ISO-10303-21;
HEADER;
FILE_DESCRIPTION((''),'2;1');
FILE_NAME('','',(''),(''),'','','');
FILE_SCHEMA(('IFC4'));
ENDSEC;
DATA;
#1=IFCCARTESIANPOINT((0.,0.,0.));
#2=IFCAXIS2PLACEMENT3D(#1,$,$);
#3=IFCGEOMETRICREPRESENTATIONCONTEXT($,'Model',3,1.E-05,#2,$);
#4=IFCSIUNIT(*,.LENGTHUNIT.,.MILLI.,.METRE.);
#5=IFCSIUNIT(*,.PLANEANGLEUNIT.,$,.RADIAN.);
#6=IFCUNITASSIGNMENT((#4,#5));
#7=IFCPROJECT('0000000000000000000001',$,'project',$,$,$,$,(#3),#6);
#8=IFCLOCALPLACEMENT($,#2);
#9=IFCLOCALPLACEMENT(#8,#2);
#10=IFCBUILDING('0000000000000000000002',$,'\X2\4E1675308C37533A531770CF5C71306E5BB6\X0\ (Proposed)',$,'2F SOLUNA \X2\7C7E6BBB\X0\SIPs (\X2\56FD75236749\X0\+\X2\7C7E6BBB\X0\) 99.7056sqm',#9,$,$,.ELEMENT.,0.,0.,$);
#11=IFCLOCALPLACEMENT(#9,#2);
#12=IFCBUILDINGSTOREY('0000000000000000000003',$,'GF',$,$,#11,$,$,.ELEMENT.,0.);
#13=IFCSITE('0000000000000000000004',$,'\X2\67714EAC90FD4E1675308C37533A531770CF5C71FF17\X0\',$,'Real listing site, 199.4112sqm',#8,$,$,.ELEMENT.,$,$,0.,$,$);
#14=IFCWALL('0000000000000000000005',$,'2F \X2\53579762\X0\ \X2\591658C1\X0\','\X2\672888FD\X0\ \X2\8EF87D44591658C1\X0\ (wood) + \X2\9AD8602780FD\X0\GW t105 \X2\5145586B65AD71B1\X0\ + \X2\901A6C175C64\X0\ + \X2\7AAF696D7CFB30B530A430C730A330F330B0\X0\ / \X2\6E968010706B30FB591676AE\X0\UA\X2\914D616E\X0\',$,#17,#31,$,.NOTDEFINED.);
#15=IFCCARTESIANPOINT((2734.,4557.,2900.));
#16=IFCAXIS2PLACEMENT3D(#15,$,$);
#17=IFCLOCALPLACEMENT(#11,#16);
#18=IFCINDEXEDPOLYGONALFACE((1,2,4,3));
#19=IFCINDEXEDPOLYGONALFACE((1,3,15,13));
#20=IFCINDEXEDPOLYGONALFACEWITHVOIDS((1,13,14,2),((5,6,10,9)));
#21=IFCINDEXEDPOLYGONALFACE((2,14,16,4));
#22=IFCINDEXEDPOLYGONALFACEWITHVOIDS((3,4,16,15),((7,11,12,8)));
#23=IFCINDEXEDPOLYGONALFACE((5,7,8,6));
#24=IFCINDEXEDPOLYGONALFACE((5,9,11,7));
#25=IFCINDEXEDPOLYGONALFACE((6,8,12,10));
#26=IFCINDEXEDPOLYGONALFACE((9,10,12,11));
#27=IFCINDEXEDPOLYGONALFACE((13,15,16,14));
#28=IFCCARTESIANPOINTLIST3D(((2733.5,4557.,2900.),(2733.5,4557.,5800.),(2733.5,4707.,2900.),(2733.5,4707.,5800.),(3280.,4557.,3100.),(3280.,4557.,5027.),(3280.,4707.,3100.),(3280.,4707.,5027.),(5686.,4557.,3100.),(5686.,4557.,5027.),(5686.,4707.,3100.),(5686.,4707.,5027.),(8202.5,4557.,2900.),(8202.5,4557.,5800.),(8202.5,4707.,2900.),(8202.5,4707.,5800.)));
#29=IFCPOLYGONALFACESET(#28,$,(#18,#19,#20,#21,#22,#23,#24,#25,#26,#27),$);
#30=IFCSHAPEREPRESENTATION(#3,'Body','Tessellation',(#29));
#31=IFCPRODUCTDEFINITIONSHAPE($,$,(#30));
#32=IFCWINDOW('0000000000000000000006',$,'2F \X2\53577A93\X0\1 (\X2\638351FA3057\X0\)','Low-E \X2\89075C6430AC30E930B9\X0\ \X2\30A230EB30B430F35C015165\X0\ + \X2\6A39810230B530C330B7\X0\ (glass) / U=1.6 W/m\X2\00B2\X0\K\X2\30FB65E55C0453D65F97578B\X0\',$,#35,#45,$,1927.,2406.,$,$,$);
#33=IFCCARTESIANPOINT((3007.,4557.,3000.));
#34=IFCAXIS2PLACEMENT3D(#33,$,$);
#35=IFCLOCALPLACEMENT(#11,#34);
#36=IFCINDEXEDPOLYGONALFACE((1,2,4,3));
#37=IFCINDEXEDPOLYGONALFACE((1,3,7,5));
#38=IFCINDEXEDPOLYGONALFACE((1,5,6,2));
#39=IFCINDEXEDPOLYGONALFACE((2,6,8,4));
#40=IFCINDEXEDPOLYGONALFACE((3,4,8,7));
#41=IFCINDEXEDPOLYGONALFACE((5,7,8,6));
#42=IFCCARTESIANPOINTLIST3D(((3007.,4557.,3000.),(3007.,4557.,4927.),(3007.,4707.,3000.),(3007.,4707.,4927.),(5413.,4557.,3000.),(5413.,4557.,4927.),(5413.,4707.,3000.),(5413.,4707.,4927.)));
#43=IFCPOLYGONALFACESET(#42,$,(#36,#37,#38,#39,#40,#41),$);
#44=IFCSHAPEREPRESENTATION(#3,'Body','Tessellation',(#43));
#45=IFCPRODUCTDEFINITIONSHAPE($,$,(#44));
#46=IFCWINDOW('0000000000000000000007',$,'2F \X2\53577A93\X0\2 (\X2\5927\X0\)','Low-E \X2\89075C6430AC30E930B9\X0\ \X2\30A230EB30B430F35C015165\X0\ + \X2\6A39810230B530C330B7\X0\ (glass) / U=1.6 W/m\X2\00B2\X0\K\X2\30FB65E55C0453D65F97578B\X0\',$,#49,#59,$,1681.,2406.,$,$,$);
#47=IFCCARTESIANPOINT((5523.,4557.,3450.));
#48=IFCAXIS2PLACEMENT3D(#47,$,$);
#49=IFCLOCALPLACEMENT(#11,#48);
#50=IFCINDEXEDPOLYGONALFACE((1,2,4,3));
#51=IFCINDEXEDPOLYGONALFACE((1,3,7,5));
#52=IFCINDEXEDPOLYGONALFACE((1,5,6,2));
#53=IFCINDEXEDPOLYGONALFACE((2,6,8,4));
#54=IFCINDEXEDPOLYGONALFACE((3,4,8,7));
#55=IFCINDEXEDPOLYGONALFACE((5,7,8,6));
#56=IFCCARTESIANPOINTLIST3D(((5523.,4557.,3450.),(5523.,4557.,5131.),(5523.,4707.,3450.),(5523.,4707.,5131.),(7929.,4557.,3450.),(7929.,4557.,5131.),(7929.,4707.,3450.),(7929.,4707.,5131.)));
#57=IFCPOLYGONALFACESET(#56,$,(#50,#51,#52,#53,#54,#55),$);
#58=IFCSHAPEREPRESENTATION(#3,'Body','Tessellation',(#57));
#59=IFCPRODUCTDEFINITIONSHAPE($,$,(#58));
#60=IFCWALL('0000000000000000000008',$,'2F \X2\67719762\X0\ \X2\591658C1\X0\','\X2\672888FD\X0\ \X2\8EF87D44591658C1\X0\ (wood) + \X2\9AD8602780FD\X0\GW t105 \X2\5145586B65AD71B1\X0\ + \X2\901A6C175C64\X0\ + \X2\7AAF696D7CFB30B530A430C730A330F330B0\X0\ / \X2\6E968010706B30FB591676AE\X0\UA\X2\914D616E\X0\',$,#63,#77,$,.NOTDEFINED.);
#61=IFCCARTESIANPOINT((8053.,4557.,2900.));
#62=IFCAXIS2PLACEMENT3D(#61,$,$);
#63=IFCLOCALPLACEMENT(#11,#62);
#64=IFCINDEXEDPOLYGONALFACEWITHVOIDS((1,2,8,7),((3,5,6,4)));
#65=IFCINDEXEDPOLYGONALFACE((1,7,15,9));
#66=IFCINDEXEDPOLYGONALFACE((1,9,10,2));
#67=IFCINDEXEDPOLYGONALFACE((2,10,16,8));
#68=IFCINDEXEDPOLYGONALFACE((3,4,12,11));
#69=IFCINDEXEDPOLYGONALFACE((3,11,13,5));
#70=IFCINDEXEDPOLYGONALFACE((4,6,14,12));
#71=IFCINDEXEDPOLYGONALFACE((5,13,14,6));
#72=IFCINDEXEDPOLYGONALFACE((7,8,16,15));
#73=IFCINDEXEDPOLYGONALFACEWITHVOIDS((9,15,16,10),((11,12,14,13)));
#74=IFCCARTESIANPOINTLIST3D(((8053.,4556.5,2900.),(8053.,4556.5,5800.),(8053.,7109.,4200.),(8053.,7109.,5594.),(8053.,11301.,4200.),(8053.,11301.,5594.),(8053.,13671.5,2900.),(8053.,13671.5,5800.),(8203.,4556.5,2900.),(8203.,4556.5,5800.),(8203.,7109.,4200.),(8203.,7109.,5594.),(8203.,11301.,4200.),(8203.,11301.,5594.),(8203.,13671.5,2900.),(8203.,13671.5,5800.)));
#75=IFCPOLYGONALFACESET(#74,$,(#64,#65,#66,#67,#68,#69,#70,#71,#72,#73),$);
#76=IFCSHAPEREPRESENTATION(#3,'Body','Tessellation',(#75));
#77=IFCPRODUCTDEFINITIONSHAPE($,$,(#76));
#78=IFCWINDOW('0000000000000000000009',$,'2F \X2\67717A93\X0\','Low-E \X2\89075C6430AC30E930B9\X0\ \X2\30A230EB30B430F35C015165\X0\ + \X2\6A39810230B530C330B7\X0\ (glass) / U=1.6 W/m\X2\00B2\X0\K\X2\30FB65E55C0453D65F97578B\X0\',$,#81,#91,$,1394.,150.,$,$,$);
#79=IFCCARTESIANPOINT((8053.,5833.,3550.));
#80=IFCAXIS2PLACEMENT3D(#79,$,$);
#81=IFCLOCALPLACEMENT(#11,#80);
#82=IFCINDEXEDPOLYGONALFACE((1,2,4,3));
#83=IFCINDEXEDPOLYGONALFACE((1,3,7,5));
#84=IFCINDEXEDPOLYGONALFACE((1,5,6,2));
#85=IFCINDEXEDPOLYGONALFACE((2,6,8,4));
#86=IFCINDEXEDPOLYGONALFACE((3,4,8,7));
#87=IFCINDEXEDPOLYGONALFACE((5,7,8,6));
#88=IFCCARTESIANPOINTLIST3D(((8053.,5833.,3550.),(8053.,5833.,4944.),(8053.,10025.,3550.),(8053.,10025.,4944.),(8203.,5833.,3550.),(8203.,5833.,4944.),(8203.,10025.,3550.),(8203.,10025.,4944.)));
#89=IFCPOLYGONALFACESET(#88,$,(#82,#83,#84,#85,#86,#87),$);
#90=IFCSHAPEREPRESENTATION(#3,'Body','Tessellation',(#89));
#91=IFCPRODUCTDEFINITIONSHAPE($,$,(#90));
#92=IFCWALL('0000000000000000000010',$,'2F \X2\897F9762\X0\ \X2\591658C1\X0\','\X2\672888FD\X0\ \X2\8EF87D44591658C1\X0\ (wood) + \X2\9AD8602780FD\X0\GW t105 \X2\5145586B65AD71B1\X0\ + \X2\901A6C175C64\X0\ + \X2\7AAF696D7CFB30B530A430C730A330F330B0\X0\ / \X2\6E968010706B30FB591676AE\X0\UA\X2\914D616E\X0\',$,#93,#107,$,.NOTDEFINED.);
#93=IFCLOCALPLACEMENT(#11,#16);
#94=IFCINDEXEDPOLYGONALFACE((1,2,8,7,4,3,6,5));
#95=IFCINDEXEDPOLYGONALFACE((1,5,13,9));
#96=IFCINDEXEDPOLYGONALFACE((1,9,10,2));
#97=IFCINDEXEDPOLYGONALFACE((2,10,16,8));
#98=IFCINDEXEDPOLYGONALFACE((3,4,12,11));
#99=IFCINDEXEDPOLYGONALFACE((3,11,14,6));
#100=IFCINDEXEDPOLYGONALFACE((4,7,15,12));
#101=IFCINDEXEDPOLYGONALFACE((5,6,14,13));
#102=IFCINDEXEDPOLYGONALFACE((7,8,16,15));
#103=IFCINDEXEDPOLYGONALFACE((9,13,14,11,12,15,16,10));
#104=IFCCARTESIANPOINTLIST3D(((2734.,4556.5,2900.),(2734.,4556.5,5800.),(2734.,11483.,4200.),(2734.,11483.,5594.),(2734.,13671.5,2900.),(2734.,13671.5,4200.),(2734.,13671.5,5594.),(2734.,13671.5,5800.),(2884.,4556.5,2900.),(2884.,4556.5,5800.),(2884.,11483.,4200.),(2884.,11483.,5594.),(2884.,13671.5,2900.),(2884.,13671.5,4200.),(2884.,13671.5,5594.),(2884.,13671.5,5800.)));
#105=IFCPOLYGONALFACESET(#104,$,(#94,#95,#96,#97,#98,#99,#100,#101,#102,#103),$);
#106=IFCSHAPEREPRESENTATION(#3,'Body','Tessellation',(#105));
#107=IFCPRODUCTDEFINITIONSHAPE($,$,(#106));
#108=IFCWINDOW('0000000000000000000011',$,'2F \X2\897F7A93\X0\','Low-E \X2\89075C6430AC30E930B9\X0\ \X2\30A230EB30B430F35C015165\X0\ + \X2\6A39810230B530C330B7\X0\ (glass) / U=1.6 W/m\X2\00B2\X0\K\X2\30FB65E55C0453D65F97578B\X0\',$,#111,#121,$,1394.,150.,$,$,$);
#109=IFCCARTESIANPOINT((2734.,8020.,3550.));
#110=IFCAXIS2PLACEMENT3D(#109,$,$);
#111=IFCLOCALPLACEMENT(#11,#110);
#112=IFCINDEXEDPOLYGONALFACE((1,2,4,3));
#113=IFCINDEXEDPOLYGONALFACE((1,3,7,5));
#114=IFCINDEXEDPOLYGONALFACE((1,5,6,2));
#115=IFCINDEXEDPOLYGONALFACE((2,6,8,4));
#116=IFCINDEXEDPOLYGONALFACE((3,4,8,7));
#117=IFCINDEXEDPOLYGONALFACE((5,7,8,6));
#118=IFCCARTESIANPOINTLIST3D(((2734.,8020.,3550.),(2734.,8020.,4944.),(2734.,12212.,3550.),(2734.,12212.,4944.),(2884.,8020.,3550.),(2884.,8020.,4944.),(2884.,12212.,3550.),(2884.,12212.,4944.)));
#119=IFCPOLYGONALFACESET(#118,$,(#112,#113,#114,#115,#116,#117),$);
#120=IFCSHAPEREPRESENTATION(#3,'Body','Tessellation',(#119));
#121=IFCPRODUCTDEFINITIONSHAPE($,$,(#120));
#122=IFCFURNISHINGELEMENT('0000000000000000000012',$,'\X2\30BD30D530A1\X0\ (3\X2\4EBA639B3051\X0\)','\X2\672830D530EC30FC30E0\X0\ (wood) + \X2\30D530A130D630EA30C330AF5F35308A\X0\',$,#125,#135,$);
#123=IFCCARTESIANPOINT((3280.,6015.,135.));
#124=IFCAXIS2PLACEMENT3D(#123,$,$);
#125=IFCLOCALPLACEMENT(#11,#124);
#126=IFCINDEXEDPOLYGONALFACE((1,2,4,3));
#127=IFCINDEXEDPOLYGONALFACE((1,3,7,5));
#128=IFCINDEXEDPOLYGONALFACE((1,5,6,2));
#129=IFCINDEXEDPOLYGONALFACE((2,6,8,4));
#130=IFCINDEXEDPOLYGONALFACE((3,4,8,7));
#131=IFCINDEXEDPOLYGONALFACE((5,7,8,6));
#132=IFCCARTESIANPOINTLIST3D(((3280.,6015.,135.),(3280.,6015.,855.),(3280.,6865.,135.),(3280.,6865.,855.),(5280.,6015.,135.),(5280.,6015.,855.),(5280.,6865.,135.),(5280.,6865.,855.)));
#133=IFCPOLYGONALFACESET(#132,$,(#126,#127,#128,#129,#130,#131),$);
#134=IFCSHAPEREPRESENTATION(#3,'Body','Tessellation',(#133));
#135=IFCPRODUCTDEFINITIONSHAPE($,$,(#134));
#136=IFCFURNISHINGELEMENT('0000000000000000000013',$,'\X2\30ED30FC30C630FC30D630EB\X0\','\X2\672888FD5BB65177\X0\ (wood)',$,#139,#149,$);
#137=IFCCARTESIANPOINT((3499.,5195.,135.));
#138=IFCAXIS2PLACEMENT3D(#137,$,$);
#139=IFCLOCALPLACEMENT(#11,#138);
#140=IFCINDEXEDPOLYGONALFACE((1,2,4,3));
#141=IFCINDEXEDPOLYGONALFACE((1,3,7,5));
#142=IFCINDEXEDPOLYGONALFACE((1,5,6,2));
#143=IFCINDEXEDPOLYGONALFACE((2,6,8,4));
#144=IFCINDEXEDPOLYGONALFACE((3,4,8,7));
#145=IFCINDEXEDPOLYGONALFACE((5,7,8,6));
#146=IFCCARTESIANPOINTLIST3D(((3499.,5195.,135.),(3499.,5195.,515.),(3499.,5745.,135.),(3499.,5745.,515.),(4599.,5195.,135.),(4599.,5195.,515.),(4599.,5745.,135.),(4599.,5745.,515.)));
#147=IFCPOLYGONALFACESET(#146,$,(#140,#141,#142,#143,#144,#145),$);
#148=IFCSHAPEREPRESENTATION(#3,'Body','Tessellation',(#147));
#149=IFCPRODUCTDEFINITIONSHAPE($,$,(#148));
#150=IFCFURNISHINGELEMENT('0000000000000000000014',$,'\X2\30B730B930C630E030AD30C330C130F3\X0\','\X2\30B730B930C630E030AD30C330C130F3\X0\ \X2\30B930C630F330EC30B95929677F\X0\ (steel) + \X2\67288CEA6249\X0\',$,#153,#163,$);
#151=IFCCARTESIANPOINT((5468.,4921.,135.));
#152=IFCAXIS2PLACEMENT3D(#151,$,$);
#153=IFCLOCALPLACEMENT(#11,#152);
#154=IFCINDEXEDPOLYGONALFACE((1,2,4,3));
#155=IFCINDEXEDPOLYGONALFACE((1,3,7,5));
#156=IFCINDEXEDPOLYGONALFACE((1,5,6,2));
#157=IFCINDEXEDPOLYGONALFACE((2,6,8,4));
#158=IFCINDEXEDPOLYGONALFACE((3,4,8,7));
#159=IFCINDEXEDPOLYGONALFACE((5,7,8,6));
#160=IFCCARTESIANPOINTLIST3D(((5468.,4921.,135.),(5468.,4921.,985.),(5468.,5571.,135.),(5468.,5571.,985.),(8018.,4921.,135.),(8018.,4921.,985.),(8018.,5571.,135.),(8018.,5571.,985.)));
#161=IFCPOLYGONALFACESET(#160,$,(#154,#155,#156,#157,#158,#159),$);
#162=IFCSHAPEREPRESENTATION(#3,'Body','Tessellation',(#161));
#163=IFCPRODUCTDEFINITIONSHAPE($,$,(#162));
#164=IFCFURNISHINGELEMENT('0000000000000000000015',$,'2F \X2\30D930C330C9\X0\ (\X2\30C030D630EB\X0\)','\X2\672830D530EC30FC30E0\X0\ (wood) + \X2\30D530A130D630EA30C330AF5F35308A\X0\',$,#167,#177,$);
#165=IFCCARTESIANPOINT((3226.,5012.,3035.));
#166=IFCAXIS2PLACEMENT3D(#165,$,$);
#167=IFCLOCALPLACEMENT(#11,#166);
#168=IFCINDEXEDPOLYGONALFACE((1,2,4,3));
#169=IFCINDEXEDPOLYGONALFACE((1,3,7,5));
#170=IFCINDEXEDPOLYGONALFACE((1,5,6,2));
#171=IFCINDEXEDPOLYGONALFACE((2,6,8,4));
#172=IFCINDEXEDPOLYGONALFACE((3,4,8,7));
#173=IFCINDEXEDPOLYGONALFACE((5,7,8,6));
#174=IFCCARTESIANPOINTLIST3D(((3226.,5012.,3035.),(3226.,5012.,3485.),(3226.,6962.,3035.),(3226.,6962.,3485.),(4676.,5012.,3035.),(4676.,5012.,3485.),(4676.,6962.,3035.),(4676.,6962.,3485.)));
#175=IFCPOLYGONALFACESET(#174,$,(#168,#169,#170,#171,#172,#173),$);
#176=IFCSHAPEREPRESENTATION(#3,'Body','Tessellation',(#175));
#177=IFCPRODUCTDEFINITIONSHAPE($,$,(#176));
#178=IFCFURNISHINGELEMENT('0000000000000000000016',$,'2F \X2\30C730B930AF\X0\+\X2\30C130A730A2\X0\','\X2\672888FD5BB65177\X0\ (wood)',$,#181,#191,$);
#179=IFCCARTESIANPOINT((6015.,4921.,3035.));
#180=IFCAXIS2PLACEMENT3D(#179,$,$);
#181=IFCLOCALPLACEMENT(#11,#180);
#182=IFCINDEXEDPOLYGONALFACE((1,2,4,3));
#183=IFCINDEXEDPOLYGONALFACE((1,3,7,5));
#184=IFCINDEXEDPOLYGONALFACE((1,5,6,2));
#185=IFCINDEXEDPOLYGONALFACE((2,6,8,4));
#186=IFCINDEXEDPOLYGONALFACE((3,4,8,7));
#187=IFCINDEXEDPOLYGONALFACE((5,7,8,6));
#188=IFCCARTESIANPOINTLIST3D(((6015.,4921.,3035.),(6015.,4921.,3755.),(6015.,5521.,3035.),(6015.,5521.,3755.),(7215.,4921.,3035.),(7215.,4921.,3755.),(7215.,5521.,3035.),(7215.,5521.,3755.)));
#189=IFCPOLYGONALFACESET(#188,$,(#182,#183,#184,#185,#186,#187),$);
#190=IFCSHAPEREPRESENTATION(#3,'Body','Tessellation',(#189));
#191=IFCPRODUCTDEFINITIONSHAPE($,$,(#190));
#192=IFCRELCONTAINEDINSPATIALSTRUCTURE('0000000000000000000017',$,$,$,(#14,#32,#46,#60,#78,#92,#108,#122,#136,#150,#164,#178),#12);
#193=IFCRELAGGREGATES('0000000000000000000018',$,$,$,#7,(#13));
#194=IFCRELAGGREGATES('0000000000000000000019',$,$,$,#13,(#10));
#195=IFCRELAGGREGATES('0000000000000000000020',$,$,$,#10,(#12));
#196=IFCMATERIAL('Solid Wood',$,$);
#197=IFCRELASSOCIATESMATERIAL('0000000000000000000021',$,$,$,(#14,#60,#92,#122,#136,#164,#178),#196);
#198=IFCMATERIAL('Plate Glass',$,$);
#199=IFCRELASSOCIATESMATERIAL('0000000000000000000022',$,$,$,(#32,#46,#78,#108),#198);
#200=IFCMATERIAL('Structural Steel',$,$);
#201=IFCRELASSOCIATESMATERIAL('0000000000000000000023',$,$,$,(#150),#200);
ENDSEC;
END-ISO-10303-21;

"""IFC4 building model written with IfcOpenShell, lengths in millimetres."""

from ifc_helpers import new_model, si_unit, frame, frame_2d, origin, place, context, project, spatial, rectangle, extrude, material, element, fill, save


model = new_model("IFC4")

# Units and contexts
model_context = context("Model", 3, precision=1e-05, world=origin())
ifc_project = project(units=[si_unit("LENGTHUNIT", "METRE", prefix="MILLI"), si_unit("PLANEANGLEUNIT", "RADIAN")], contexts=[model_context])

# Site, building, storey
site_placement = place(None, origin())
site = spatial("IfcSite", under=ifc_project, at=site_placement, Name="東京都世田谷区北烏山７", ObjectType="Real listing site, 199.4112sqm", CompositionType="ELEMENT", RefElevation=0.0)
building_placement = place(site_placement, origin())
building = spatial("IfcBuilding", under=site, at=building_placement, Name="世田谷区北烏山の家 (Proposed)", ObjectType="2F SOLUNA 籾殻SIPs (国産杉+籾殻) 99.7056sqm", CompositionType="ELEMENT", ElevationOfRefHeight=0.0, ElevationOfTerrain=0.0)
storey_placement = place(building_placement, origin())
storey = spatial("IfcBuildingStorey", under=building, at=storey_placement, Name="GF", CompositionType="ELEMENT", Elevation=0.0)

# Shared definitions
ifc_material_1 = material(Name="Solid Wood")

# Wall, openings, windows
wall_1_placement = place(storey_placement, frame((2734.0, 4557.0, 2900.0)))
wall_1 = element("IfcWall", 1, at=wall_1_placement, inside=storey, material=ifc_material_1, Name="2F 南面 外壁", Description="木製 軸組外壁 (wood) + 高性能GW t105 充填断熱 + 通気層 + 窯業系サイディング / 準耐火・外皮UA配慮", PredefinedType="NOTDEFINED", context=model_context, shape_type="SweptSolid", body=[
    extrude(rectangle(XDim=5469.0, YDim=150.0, at=frame_2d((2734.0, 75.0))), frame((2734.0, 4557.0, 2900.0)), (0.0, 0.0, 1.0), 2900.0),
])
opening_1_placement = place(storey_placement, frame((3007.0, 4557.0, 3000.0)))
opening_1 = element("IfcOpeningElement", 2, at=opening_1_placement, cuts=wall_1, PredefinedType="NOTDEFINED", context=model_context, shape_type="SweptSolid", body=[
    extrude(rectangle(XDim=2406.0, YDim=150.0, at=frame_2d((1203.0, 75.0))), frame((3007.0, 4557.0, 3000.0)), (0.0, 0.0, 1.0), 1927.0),
])
opening_2_placement = place(storey_placement, frame((5523.0, 4557.0, 3450.0)))
opening_2 = element("IfcOpeningElement", 3, at=opening_2_placement, cuts=wall_1, PredefinedType="NOTDEFINED", context=model_context, shape_type="SweptSolid", body=[
    extrude(rectangle(XDim=2406.0, YDim=150.0, at=frame_2d((1203.0, 75.0))), frame((5523.0, 4557.0, 3450.0)), (0.0, 0.0, 1.0), 1681.0),
])
ifc_material_2 = material(Name="Plate Glass")
window_1_placement = place(storey_placement, frame((3007.0, 4557.0, 3000.0)))
window_1 = element("IfcWindow", 4, at=window_1_placement, inside=storey, material=ifc_material_2, Name="2F 南窓1 (掃出し)", Description="Low-E 複層ガラス アルゴン封入 + 樹脂サッシ (glass) / U=1.6 W/m²K・日射取得型", OverallHeight=1927.0, OverallWidth=2406.0, context=model_context, shape_type="SweptSolid", body=[
    extrude(rectangle(XDim=2406.0, YDim=150.0, at=frame_2d((1203.0, 75.0))), frame((3007.0, 4557.0, 3000.0)), (0.0, 0.0, 1.0), 1927.0),
])
fill(opening_1, window_1)
window_2_placement = place(storey_placement, frame((5523.0, 4557.0, 3450.0)))
window_2 = element("IfcWindow", 5, at=window_2_placement, inside=storey, material=ifc_material_2, Name="2F 南窓2 (大)", Description="Low-E 複層ガラス アルゴン封入 + 樹脂サッシ (glass) / U=1.6 W/m²K・日射取得型", OverallHeight=1681.0, OverallWidth=2406.0, context=model_context, shape_type="SweptSolid", body=[
    extrude(rectangle(XDim=2406.0, YDim=150.0, at=frame_2d((1203.0, 75.0))), frame((5523.0, 4557.0, 3450.0)), (0.0, 0.0, 1.0), 1681.0),
])
fill(opening_2, window_2)

# Walls, openings, windows
wall_2_placement = place(storey_placement, frame((8053.0, 4557.0, 2900.0)))
wall_2 = element("IfcWall", 6, at=wall_2_placement, inside=storey, material=ifc_material_1, Name="2F 東面 外壁", Description="木製 軸組外壁 (wood) + 高性能GW t105 充填断熱 + 通気層 + 窯業系サイディング / 準耐火・外皮UA配慮", PredefinedType="NOTDEFINED", context=model_context, shape_type="SweptSolid", body=[
    extrude(rectangle(XDim=150.0, YDim=9115.0, at=frame_2d((75.0, 4557.0))), frame((8053.0, 4557.0, 2900.0)), (0.0, 0.0, 1.0), 2900.0),
])
opening_3_placement = place(storey_placement, frame((8053.0, 5833.0, 3550.0)))
opening_3 = element("IfcOpeningElement", 7, at=opening_3_placement, cuts=wall_2, PredefinedType="NOTDEFINED", context=model_context, shape_type="SweptSolid", body=[
    extrude(rectangle(XDim=150.0, YDim=4192.0, at=frame_2d((75.0, 2096.0))), frame((8053.0, 5833.0, 3550.0)), (0.0, 0.0, 1.0), 1394.0),
])
window_3_placement = place(storey_placement, frame((8053.0, 5833.0, 3550.0)))
window_3 = element("IfcWindow", 8, at=window_3_placement, inside=storey, material=ifc_material_2, Name="2F 東窓", Description="Low-E 複層ガラス アルゴン封入 + 樹脂サッシ (glass) / U=1.6 W/m²K・日射取得型", OverallHeight=1394.0, OverallWidth=150.0, context=model_context, shape_type="SweptSolid", body=[
    extrude(rectangle(XDim=150.0, YDim=4192.0, at=frame_2d((75.0, 2096.0))), frame((8053.0, 5833.0, 3550.0)), (0.0, 0.0, 1.0), 1394.0),
])
fill(opening_3, window_3)
wall_3_placement = place(storey_placement, frame((2734.0, 4557.0, 2900.0)))
wall_3 = element("IfcWall", 9, at=wall_3_placement, inside=storey, material=ifc_material_1, Name="2F 西面 外壁", Description="木製 軸組外壁 (wood) + 高性能GW t105 充填断熱 + 通気層 + 窯業系サイディング / 準耐火・外皮UA配慮", PredefinedType="NOTDEFINED", context=model_context, shape_type="SweptSolid", body=[
    extrude(rectangle(XDim=150.0, YDim=9115.0, at=frame_2d((75.0, 4557.0))), frame((2734.0, 4557.0, 2900.0)), (0.0, 0.0, 1.0), 2900.0),
])
opening_4_placement = place(storey_placement, frame((2734.0, 8020.0, 3550.0)))
opening_4 = element("IfcOpeningElement", 10, at=opening_4_placement, cuts=wall_3, PredefinedType="NOTDEFINED", context=model_context, shape_type="SweptSolid", body=[
    extrude(rectangle(XDim=150.0, YDim=4192.0, at=frame_2d((75.0, 2096.0))), frame((2734.0, 8020.0, 3550.0)), (0.0, 0.0, 1.0), 1394.0),
])
window_4_placement = place(storey_placement, frame((2734.0, 8020.0, 3550.0)))
window_4 = element("IfcWindow", 11, at=window_4_placement, inside=storey, material=ifc_material_2, Name="2F 西窓", Description="Low-E 複層ガラス アルゴン封入 + 樹脂サッシ (glass) / U=1.6 W/m²K・日射取得型", OverallHeight=1394.0, OverallWidth=150.0, context=model_context, shape_type="SweptSolid", body=[
    extrude(rectangle(XDim=150.0, YDim=4192.0, at=frame_2d((75.0, 2096.0))), frame((2734.0, 8020.0, 3550.0)), (0.0, 0.0, 1.0), 1394.0),
])
fill(opening_4, window_4)

# Shared definitions
ifc_material_3 = material(Name="Structural Steel")

# Furnishing elements
furnishing_1_placement = place(storey_placement, frame((3280.0, 6015.0, 135.0)))
element("IfcFurnishingElement", 12, at=furnishing_1_placement, inside=storey, material=ifc_material_1, Name="ソファ (3人掛け)", Description="木フレーム (wood) + ファブリック張り", context=model_context, shape_type="SweptSolid", body=[
    extrude(rectangle(XDim=2000.0, YDim=850.0, at=frame_2d((1000.0, 425.0))), frame((3280.0, 6015.0, 135.0)), (0.0, 0.0, 1.0), 720.0),
])
furnishing_2_placement = place(storey_placement, frame((3499.0, 5195.0, 135.0)))
element("IfcFurnishingElement", 13, at=furnishing_2_placement, inside=storey, material=ifc_material_1, Name="ローテーブル", Description="木製家具 (wood)", context=model_context, shape_type="SweptSolid", body=[
    extrude(rectangle(XDim=1100.0, YDim=550.0, at=frame_2d((550.0, 275.0))), frame((3499.0, 5195.0, 135.0)), (0.0, 0.0, 1.0), 380.0),
])
furnishing_3_placement = place(storey_placement, frame((5468.0, 4921.0, 135.0)))
element("IfcFurnishingElement", 14, at=furnishing_3_placement, inside=storey, material=ifc_material_3, Name="システムキッチン", Description="システムキッチン ステンレス天板 (steel) + 木質扉", context=model_context, shape_type="SweptSolid", body=[
    extrude(rectangle(XDim=2550.0, YDim=650.0, at=frame_2d((1275.0, 325.0))), frame((5468.0, 4921.0, 135.0)), (0.0, 0.0, 1.0), 850.0),
])
furnishing_4_placement = place(storey_placement, frame((3226.0, 5012.0, 3035.0)))
element("IfcFurnishingElement", 15, at=furnishing_4_placement, inside=storey, material=ifc_material_1, Name="2F ベッド (ダブル)", Description="木フレーム (wood) + ファブリック張り", context=model_context, shape_type="SweptSolid", body=[
    extrude(rectangle(XDim=1450.0, YDim=1950.0, at=frame_2d((725.0, 975.0))), frame((3226.0, 5012.0, 3035.0)), (0.0, 0.0, 1.0), 450.0),
])
furnishing_5_placement = place(storey_placement, frame((6015.0, 4921.0, 3035.0)))
element("IfcFurnishingElement", 16, at=furnishing_5_placement, inside=storey, material=ifc_material_1, Name="2F デスク+チェア", Description="木製家具 (wood)", context=model_context, shape_type="SweptSolid", body=[
    extrude(rectangle(XDim=1200.0, YDim=600.0, at=frame_2d((600.0, 300.0))), frame((6015.0, 4921.0, 3035.0)), (0.0, 0.0, 1.0), 720.0),
])

save(model, "model.ifc")
